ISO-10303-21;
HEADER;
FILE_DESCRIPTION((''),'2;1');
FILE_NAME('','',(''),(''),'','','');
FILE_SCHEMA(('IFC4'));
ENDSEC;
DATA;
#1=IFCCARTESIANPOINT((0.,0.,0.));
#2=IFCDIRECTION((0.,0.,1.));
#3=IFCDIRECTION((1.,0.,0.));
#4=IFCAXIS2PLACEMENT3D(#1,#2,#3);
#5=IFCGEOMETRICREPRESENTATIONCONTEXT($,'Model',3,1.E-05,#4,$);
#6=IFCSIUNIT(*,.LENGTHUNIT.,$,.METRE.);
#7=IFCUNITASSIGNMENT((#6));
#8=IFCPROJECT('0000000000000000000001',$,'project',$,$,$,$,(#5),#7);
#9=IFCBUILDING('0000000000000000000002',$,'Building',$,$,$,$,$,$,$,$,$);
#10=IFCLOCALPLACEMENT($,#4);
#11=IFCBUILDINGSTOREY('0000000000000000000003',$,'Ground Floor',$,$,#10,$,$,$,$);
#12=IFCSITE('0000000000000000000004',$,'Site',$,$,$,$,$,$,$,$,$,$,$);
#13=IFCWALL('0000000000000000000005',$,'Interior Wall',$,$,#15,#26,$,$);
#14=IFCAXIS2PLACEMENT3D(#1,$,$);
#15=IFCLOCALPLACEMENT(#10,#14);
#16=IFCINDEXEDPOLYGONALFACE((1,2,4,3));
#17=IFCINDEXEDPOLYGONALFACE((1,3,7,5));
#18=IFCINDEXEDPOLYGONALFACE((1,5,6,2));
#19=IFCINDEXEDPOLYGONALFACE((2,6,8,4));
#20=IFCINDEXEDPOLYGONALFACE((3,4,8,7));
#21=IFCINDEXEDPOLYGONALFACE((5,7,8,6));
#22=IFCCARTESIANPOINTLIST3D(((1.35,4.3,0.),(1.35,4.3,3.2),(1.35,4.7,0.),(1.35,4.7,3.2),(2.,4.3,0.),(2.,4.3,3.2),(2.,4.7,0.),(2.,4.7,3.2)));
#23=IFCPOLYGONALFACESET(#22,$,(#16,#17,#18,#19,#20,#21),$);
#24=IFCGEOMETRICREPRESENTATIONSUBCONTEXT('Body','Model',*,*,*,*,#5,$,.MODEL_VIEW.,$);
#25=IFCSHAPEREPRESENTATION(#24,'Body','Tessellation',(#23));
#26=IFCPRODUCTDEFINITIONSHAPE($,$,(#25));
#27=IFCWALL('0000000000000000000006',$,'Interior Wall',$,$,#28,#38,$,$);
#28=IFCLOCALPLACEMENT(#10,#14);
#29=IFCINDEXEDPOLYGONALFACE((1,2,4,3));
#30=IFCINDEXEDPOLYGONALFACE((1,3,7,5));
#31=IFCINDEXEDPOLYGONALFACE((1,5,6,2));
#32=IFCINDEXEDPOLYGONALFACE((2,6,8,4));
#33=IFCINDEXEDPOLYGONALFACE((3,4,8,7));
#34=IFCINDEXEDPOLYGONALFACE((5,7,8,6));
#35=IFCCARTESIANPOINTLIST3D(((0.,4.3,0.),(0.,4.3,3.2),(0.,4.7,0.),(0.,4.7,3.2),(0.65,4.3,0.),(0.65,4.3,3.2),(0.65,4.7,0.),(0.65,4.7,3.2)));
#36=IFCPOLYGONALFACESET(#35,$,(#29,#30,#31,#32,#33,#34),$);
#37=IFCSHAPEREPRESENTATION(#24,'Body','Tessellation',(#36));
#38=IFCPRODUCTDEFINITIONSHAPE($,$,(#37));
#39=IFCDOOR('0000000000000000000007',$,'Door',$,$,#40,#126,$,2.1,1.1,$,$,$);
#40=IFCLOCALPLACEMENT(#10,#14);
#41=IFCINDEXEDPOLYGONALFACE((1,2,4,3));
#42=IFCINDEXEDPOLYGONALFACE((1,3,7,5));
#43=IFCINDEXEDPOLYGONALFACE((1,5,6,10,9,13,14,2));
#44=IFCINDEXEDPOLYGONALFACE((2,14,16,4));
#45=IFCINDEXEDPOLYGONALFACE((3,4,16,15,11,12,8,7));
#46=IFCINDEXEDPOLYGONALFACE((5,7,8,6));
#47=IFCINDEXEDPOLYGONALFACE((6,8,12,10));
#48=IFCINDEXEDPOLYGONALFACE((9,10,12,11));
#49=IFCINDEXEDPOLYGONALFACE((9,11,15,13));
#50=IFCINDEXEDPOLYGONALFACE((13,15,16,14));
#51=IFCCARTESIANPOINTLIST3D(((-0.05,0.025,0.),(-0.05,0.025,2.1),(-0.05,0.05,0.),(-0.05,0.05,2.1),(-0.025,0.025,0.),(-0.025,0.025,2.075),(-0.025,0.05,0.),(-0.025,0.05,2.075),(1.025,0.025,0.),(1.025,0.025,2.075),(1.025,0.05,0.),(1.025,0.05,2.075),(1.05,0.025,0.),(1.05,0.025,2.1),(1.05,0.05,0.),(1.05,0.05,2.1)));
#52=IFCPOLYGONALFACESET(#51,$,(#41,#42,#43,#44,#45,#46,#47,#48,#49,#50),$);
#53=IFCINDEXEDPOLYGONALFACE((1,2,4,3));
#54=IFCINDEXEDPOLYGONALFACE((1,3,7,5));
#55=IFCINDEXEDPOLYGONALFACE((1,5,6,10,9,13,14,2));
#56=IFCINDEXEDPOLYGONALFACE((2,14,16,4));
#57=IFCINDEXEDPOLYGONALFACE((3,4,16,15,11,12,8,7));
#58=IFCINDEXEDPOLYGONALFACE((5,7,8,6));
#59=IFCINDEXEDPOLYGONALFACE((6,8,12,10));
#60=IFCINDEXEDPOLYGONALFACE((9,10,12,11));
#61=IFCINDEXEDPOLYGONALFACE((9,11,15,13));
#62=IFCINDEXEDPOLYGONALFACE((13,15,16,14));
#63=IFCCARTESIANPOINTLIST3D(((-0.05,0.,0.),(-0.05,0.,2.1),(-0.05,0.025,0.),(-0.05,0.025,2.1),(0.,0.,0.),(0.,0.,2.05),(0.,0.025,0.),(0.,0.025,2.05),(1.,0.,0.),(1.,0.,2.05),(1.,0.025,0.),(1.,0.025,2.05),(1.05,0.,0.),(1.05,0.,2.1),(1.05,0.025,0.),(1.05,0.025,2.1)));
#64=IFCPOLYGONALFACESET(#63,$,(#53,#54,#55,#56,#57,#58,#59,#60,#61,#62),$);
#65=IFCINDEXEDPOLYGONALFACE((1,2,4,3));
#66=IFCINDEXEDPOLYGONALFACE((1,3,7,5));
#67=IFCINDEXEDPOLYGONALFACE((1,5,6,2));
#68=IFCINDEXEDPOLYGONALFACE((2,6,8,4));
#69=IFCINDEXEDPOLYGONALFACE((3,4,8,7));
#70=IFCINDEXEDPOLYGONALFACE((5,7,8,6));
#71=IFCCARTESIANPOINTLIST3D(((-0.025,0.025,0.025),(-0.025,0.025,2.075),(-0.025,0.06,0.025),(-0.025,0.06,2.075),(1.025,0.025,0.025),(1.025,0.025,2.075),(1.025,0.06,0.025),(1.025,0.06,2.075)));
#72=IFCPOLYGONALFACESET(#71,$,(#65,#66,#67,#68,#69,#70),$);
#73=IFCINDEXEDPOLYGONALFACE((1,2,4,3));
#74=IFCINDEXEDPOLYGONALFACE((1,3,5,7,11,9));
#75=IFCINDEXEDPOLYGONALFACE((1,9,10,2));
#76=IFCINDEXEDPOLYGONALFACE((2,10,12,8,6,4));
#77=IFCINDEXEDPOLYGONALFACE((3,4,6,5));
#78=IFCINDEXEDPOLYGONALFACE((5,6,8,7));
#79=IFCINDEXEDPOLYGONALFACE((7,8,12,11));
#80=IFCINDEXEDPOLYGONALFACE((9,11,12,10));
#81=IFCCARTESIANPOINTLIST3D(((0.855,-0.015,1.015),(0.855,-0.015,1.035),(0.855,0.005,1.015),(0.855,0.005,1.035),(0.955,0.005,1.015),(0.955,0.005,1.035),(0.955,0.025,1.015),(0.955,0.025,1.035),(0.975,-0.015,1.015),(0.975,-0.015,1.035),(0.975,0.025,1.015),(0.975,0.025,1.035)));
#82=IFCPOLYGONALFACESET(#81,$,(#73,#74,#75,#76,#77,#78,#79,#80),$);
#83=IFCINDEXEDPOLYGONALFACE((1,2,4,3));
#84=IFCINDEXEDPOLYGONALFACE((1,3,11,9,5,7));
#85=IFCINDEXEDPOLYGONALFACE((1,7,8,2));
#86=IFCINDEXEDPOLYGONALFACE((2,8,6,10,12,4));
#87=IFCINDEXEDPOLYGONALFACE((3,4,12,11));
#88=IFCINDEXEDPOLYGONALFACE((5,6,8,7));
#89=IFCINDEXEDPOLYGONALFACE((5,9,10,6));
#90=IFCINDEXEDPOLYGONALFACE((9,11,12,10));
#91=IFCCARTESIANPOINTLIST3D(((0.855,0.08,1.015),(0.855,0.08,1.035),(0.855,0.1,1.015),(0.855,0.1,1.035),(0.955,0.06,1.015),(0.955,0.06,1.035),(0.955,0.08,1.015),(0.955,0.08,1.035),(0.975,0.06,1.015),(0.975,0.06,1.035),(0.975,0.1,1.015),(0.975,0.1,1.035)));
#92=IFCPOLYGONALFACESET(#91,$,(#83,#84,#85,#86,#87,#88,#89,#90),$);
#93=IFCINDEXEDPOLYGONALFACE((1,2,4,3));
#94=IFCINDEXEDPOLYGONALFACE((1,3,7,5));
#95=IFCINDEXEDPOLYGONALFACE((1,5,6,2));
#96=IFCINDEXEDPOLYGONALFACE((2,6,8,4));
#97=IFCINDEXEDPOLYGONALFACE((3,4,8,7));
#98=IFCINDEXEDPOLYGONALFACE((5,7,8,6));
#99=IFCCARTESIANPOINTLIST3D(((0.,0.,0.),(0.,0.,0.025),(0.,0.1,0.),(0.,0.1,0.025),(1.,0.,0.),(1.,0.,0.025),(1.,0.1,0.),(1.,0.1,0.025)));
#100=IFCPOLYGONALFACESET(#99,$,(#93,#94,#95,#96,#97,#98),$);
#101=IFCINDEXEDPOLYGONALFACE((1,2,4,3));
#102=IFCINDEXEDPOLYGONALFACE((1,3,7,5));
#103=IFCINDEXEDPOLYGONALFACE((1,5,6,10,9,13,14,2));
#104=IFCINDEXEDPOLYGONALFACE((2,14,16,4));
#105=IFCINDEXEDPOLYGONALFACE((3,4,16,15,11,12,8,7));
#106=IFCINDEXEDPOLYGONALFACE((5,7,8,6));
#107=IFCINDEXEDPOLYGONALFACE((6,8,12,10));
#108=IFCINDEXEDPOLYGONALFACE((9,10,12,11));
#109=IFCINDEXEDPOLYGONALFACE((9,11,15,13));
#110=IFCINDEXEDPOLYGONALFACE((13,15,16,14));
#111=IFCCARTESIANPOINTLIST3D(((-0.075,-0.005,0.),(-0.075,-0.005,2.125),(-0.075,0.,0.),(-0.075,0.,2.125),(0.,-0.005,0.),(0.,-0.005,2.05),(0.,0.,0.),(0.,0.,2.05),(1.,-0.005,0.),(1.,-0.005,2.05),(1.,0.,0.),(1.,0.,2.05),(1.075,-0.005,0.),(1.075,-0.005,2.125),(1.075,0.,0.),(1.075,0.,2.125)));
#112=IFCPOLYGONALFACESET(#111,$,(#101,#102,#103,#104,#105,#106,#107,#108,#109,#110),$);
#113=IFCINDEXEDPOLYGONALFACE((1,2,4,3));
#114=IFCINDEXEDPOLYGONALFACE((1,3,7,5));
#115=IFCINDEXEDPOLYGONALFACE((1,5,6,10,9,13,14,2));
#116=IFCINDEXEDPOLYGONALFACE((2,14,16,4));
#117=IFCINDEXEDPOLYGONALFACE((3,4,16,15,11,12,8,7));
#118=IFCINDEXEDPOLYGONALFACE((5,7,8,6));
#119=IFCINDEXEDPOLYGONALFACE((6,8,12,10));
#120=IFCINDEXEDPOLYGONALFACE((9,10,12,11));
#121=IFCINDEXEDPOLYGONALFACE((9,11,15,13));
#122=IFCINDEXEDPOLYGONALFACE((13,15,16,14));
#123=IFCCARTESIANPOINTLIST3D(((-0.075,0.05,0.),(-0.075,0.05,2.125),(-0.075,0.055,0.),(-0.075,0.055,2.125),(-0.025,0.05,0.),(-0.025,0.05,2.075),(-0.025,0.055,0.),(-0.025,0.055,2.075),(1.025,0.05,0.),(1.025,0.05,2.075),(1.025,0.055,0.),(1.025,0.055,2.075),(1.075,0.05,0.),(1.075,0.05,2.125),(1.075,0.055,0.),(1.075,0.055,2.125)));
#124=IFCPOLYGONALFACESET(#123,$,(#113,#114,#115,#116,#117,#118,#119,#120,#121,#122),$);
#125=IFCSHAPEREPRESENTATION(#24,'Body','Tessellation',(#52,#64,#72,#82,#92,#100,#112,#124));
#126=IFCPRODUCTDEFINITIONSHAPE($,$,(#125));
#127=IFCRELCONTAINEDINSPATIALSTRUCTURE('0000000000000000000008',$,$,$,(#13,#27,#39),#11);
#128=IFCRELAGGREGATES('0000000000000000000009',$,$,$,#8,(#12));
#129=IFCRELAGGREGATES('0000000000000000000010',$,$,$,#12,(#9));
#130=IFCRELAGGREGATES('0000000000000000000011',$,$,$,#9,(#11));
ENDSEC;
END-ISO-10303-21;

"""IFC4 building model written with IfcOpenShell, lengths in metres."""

from ifc_helpers import new_model, si_unit, frame, origin_with_axes, place, context, subcontext, project, spatial, line, indexed_curve, outline, extrude, element, save


model = new_model("IFC4")

# Units and contexts
model_context = context("Model", 3, precision=1e-05, world=origin_with_axes())
body_context = subcontext(model_context, "Body", "Model", "MODEL_VIEW")
ifc_project = project(units=[si_unit("LENGTHUNIT", "METRE")], contexts=[model_context])

# Site, building, storey
site = spatial("IfcSite", under=ifc_project, Name="Site")
building = spatial("IfcBuilding", under=site, Name="Building")
storey_placement = place(None, origin_with_axes())
storey = spatial("IfcBuildingStorey", under=building, at=storey_placement, Name="Ground Floor")

# Walls
for number, where, z_axis, x_axis, name in (
    (1, (2.0, 4.5, 0.0), (0.0, 0.0, 1.0), (-1.0, 0.0, 0.0), "Interior Wall"),
    (2, (0.65, 4.5, 0.0), (0.0, 0.0, 1.0), (-1.0, 0.0, 0.0), "Interior Wall"),
):
    element("IfcWall", number, at=place(storey_placement, frame(where, z_axis=z_axis, x_axis=x_axis)), inside=storey, Name=name, context=body_context, shape_type="SweptSolid", body=[
        extrude(outline(indexed_curve([(0.0, 0.0), (0.0, 0.4), (0.65, 0.4), (0.65, 0.0), (0.0, 0.0)], self_intersect=False)), frame((0.0, -0.2, 0.0), z_axis=(0.0, 0.0, 1.0), x_axis=(1.0, 0.0, 0.0)), (0.0, 0.0, 1.0), 3.2),
    ])

# Door
door_1_placement = place(storey_placement, frame((-0.05, 0.0, 0.0), z_axis=(0.0, 0.0, 1.0), x_axis=(1.0, 0.0, 0.0)))
element("IfcDoor", 3, at=door_1_placement, inside=storey, Name="Door", OverallHeight=2.1, OverallWidth=1.1, context=body_context, shape_type="SweptSolid", body=[
    extrude(outline(indexed_curve([(0.0, 0.0), (0.0, 2.1), (1.1, 2.1), (1.1, 0.0), (1.075, 0.0), (1.075, 2.075), (0.025, 2.075), (0.025, 0.0)], segments=[line(1, 2, 3, 4, 5, 6, 7, 8, 1)])), frame((0.0, 0.025, 0.0), z_axis=(0.0, -1.0, 0.0), x_axis=(1.0, 0.0, 0.0)), (0.0, 0.0, -1.0), 0.025),
    extrude(outline(indexed_curve([(0.0, 0.0), (0.0, 2.1), (1.1, 2.1), (1.1, 0.0), (1.05, 0.0), (1.05, 2.05), (0.05, 2.05), (0.05, 0.0)], segments=[line(1, 2, 3, 4, 5, 6, 7, 8, 1)])), frame((0.0, 0.0, 0.0), z_axis=(0.0, -1.0, 0.0), x_axis=(1.0, 0.0, 0.0)), (0.0, 0.0, -1.0), 0.025),
    extrude(outline(indexed_curve([(0.0, 0.0), (1.05, 0.0), (1.05, 0.035), (0.0, 0.035)], segments=[line(1, 2, 3, 4, 1)])), frame((0.025, 0.025, 0.025), z_axis=(0.0, 0.0, 1.0), x_axis=(1.0, 0.0, 0.0)), (0.0, 0.0, 1.0), 2.05),
    extrude(outline(indexed_curve([(0.0, 0.0), (0.0, -0.04), (-0.12, -0.04), (-0.12, -0.02), (-0.02, -0.02), (-0.02, 0.0)], segments=[line(1, 2, 3, 4, 5, 6, 1)])), frame((1.025, 0.025, 1.015), z_axis=(0.0, 0.0, 1.0), x_axis=(1.0, 0.0, 0.0)), (0.0, 0.0, 1.0), 0.02),
    extrude(outline(indexed_curve([(0.0, 0.0), (0.0, 0.04), (-0.12, 0.04), (-0.12, 0.02), (-0.02, 0.02), (-0.02, 0.0)], segments=[line(1, 2, 3, 4, 5, 6, 1)])), frame((1.025, 0.06, 1.015), z_axis=(0.0, 0.0, 1.0), x_axis=(1.0, 0.0, 0.0)), (0.0, 0.0, 1.0), 0.02),
    extrude(outline(indexed_curve([(0.0, 0.0), (1.0, 0.0), (1.0, 0.1), (0.0, 0.1)], segments=[line(1, 2, 3, 4, 1)])), frame((0.05, 0.0, 0.0), z_axis=(0.0, 0.0, 1.0), x_axis=(1.0, 0.0, 0.0)), (0.0, 0.0, 1.0), 0.025),
    extrude(outline(indexed_curve([(0.0, 0.0), (0.0, 2.125), (1.15, 2.125), (1.15, 0.0), (1.075, 0.0), (1.075, 2.05), (0.075, 2.05), (0.075, 0.0)], segments=[line(1, 2, 3, 4, 5, 6, 7, 8, 1)])), frame((-0.025, -0.005, 0.0), z_axis=(0.0, -1.0, 0.0), x_axis=(1.0, 0.0, 0.0)), (0.0, 0.0, -1.0), 0.005),
    extrude(outline(indexed_curve([(0.0, 0.0), (0.0, 2.125), (1.15, 2.125), (1.15, 0.0), (1.1, 0.0), (1.1, 2.075), (0.05, 2.075), (0.05, 0.0)], segments=[line(1, 2, 3, 4, 5, 6, 7, 8, 1)])), frame((-0.025, 0.05, 0.0), z_axis=(0.0, -1.0, 0.0), x_axis=(1.0, 0.0, 0.0)), (0.0, 0.0, -1.0), 0.005),
])

save(model, "model.ifc")
